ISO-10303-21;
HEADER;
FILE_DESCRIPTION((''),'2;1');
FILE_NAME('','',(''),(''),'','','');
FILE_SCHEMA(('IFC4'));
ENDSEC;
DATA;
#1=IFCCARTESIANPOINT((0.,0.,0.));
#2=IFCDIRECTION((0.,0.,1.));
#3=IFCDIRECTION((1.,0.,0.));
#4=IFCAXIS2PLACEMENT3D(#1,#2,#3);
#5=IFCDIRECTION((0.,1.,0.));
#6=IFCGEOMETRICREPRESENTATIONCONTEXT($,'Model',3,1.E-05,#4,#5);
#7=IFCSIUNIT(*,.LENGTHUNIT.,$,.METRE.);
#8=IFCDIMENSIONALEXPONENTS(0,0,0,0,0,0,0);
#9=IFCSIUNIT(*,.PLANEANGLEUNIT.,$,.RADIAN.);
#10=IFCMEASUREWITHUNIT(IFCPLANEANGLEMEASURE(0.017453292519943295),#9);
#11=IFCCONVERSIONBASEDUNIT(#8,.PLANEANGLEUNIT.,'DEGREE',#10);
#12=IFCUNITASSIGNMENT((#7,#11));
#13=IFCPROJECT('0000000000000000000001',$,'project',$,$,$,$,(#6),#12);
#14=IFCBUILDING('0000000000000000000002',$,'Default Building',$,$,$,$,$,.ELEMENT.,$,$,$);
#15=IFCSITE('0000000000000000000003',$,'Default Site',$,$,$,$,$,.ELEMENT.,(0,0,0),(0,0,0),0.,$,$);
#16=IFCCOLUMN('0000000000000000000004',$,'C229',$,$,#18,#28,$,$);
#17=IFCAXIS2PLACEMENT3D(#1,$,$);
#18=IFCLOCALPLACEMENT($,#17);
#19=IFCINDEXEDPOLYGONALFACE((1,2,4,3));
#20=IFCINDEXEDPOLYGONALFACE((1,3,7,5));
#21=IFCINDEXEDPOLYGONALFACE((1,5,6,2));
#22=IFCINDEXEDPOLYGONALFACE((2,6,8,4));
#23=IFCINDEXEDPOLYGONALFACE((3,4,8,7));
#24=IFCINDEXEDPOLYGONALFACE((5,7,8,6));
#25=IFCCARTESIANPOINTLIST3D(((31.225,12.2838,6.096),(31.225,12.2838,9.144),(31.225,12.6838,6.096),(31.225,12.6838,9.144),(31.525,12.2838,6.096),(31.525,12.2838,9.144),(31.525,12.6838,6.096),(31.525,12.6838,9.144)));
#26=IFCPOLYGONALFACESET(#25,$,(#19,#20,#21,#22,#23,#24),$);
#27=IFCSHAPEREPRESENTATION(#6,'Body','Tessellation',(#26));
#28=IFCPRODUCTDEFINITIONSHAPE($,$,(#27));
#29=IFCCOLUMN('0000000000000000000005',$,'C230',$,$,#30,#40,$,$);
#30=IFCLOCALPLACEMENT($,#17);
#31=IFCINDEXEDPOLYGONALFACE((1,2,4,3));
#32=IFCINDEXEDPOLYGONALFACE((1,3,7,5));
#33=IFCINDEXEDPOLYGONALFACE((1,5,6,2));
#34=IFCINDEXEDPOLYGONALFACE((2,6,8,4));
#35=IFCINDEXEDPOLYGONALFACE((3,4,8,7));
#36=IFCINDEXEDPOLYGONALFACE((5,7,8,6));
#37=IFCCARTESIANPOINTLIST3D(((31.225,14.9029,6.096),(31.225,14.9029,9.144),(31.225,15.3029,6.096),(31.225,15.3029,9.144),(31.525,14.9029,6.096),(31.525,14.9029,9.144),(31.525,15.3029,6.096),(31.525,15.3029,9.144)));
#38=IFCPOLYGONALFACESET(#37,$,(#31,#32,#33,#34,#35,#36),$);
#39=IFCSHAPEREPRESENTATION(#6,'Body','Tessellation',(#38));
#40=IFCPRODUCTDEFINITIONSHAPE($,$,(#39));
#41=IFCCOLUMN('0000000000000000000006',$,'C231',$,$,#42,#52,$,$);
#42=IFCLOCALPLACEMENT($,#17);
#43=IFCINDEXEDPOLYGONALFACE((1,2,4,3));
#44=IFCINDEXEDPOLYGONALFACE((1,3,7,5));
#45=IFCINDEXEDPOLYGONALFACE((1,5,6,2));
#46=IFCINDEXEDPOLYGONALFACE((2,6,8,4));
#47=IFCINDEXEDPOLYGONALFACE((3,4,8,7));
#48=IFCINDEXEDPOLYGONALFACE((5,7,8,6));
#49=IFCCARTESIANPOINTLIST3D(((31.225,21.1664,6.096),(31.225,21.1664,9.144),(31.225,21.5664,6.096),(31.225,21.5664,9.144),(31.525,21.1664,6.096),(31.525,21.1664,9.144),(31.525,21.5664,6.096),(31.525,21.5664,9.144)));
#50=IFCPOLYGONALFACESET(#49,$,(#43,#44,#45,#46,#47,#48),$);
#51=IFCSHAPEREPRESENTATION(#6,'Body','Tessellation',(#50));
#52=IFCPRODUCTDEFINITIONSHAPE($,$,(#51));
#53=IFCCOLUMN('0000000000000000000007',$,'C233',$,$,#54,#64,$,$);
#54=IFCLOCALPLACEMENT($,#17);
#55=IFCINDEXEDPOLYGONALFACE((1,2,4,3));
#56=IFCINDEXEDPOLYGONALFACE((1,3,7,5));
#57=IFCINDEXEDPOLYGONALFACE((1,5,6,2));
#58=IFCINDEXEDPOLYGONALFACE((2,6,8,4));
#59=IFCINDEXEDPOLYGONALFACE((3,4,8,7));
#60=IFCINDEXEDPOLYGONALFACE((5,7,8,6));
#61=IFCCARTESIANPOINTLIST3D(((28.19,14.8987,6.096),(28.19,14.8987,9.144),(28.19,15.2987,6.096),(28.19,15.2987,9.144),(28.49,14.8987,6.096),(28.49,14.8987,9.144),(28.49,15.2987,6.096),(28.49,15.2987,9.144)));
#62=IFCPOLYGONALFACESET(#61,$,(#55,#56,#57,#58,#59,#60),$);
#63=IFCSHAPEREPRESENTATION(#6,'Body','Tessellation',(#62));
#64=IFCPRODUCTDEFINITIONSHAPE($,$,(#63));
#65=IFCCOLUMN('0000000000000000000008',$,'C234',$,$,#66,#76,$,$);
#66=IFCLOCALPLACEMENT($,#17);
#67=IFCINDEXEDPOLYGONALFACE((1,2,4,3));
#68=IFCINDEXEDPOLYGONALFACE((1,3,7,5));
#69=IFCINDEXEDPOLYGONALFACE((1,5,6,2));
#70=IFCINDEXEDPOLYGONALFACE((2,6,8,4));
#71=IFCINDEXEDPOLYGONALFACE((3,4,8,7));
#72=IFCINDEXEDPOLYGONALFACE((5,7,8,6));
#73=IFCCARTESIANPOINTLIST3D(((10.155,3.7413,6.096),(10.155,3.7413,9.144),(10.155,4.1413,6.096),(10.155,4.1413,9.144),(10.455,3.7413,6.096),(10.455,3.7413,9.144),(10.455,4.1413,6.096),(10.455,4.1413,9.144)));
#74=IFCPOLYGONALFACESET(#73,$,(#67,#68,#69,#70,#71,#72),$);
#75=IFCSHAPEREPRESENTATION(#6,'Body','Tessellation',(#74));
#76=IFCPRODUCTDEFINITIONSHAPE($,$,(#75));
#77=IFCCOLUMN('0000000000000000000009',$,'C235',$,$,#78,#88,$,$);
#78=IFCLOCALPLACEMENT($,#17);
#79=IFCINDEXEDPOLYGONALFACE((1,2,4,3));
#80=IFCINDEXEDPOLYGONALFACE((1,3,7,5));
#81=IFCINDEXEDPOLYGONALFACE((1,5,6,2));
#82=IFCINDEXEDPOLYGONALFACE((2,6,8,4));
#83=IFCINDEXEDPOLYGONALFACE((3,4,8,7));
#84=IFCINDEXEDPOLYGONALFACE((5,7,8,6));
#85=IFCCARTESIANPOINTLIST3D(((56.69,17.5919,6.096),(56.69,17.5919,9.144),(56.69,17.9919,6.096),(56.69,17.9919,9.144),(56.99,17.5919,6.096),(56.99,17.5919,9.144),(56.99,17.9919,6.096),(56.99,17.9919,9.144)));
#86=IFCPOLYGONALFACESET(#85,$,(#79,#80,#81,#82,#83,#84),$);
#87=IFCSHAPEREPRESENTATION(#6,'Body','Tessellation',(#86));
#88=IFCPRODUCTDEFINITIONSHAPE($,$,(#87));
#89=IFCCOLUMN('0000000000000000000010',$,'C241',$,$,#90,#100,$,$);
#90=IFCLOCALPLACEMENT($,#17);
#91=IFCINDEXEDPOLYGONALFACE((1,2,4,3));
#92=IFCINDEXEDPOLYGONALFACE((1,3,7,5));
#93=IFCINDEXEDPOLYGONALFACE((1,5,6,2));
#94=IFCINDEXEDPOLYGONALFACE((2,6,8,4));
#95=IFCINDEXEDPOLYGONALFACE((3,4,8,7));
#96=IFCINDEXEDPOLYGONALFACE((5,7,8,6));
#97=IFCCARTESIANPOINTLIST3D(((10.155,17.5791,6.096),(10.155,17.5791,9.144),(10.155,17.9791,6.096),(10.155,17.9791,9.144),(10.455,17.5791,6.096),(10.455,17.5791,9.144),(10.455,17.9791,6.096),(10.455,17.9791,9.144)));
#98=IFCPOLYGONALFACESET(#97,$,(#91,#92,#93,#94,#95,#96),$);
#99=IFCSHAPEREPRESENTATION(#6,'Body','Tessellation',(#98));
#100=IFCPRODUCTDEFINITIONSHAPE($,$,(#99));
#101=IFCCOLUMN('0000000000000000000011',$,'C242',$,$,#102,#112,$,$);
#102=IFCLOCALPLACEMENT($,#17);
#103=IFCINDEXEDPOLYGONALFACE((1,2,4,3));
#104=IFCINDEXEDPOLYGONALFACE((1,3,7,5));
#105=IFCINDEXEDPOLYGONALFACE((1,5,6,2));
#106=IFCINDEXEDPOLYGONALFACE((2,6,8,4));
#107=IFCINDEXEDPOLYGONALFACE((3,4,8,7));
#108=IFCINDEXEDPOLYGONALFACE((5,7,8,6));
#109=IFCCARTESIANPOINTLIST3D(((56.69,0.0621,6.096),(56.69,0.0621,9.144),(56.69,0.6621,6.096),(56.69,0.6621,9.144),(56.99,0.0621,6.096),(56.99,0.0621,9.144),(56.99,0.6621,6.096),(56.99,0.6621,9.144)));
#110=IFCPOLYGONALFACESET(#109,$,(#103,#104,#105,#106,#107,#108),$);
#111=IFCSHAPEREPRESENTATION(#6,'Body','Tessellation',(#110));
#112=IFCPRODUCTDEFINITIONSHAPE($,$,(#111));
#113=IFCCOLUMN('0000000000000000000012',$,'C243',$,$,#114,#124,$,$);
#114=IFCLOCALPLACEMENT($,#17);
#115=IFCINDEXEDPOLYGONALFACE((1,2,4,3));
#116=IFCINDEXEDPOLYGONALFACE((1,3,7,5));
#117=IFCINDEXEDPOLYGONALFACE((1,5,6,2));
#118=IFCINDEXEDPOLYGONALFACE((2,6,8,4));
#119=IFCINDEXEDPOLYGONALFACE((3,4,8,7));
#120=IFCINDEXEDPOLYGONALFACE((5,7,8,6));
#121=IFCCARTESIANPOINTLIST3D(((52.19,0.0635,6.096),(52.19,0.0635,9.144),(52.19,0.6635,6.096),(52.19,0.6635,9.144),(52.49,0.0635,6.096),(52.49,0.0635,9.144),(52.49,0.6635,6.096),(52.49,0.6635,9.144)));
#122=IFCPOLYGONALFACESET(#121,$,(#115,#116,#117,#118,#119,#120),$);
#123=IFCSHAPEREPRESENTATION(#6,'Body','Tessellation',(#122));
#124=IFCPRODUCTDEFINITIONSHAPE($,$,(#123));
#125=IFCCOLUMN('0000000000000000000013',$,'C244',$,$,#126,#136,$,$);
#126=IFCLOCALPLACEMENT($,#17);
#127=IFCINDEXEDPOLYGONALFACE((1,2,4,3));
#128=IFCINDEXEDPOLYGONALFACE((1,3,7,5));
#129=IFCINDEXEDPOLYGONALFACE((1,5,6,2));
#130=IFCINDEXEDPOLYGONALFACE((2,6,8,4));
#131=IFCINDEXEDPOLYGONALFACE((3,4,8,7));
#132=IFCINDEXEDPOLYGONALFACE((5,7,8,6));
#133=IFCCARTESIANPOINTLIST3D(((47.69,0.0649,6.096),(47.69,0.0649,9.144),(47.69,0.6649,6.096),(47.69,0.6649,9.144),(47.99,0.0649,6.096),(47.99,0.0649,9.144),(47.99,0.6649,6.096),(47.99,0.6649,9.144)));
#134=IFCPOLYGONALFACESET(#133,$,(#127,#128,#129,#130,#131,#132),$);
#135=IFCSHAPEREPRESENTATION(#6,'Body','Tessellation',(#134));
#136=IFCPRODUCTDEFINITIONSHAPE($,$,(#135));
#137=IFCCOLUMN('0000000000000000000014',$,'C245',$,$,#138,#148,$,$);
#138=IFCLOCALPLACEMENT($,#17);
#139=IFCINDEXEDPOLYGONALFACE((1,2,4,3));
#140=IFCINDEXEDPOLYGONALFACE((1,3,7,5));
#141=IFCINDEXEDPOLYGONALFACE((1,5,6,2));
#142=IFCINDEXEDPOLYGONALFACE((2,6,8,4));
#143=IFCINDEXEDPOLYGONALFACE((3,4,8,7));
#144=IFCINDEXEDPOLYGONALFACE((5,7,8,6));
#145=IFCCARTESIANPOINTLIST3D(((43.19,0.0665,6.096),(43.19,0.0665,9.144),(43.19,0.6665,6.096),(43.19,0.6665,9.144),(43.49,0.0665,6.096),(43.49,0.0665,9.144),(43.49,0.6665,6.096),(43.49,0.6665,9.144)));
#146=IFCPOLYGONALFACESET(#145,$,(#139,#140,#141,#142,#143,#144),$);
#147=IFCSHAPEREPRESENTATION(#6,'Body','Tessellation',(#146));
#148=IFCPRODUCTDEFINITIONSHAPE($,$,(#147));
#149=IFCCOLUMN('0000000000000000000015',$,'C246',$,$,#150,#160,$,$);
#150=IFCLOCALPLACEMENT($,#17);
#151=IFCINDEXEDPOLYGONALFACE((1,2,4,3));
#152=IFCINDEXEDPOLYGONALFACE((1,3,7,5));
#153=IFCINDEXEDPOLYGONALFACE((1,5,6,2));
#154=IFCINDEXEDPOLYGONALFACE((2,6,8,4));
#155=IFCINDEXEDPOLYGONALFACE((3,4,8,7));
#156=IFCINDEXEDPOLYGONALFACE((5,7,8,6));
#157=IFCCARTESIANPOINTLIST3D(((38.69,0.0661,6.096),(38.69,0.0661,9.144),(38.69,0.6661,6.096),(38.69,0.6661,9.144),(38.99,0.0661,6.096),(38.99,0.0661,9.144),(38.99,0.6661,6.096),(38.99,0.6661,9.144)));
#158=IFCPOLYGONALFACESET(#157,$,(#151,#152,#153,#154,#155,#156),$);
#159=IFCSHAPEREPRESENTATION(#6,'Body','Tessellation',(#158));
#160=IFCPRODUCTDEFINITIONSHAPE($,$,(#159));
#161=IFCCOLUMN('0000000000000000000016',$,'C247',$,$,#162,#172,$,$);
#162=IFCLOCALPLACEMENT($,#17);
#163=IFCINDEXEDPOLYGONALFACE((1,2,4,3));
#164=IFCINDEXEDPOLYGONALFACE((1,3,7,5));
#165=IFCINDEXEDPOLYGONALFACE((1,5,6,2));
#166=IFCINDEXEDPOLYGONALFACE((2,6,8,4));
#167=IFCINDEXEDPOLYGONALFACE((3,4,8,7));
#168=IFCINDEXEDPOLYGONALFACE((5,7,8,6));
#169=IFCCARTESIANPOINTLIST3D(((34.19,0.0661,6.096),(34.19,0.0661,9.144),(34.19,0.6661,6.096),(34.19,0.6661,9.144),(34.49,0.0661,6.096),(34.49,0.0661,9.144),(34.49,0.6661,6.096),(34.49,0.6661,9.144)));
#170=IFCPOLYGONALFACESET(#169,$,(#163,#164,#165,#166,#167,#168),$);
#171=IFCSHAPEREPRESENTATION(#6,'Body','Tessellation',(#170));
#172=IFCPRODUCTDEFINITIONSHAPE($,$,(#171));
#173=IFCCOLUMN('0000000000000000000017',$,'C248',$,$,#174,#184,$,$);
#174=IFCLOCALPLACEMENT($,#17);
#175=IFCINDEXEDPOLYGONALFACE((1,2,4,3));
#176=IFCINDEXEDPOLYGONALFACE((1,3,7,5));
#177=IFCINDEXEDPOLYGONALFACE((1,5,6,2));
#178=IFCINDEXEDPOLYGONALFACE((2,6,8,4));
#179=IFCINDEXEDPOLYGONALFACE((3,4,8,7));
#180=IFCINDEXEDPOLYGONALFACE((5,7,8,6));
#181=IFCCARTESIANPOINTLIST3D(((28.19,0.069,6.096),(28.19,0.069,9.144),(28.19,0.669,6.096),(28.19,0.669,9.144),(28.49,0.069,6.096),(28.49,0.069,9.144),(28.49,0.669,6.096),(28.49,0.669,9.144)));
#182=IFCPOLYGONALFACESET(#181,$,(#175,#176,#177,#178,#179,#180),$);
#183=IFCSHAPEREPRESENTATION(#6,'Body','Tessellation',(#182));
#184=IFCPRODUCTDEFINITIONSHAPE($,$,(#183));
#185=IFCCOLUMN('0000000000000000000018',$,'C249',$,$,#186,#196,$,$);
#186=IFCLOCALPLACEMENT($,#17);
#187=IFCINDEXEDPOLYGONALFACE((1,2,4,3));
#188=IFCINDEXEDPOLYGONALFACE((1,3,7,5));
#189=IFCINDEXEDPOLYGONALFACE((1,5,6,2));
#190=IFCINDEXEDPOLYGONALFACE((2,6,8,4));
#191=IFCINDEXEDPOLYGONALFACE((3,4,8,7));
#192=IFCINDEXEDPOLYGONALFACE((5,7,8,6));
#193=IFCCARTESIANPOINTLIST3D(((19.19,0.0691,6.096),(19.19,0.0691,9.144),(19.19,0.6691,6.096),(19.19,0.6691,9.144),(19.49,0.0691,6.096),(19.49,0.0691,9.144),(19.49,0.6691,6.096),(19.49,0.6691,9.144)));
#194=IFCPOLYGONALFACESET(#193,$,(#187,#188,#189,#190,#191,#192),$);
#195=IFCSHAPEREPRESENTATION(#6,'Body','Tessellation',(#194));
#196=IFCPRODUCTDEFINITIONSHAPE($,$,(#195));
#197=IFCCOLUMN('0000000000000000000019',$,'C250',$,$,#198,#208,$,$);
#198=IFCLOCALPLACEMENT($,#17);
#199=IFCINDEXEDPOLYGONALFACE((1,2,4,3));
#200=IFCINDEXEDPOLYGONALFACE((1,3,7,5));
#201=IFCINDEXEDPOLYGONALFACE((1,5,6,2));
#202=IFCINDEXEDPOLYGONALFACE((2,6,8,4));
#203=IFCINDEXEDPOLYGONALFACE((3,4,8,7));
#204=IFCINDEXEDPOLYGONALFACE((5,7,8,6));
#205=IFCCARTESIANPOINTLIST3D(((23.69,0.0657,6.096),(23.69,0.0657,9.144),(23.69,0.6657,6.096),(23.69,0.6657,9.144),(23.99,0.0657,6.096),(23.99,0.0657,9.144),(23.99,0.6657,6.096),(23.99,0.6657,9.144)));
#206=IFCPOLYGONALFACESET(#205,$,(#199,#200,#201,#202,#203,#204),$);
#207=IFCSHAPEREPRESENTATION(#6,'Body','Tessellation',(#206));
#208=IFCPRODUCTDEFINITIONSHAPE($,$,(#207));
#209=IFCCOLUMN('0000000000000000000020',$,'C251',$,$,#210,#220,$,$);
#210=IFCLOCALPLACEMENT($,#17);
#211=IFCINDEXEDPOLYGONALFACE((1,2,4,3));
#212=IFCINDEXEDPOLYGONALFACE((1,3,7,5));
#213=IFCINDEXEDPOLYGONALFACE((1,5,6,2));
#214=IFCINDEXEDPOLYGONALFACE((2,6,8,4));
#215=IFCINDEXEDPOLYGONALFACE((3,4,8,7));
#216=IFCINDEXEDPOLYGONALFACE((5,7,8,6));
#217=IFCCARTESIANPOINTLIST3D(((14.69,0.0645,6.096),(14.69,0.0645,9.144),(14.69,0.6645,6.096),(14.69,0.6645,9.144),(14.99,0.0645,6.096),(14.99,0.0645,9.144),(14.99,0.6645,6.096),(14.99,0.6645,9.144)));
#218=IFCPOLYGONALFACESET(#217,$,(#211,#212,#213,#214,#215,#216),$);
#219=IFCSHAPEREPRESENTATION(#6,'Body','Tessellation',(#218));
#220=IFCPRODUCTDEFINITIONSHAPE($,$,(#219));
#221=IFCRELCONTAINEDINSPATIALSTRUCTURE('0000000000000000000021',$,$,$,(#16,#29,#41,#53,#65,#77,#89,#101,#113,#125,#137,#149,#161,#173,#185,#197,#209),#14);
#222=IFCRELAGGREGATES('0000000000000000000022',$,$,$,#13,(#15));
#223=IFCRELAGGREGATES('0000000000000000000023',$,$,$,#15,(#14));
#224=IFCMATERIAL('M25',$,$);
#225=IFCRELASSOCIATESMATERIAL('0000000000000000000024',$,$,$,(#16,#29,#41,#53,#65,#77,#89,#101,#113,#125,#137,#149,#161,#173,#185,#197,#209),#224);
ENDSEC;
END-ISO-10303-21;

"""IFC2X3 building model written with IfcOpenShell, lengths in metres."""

from ifc_helpers import new_model, entity, si_unit, converted_unit, direction, frame, frame_2d, origin_with_axes, place, context, project, spatial, rectangle, extrude, material, element, save


model = new_model("IFC2X3")

# Units and contexts
model_context = context("Model", 3, precision=1e-05, world=origin_with_axes(), true_north=direction((0.0, 1.0, 0.0)))
ifc_project = project(units=[si_unit("LENGTHUNIT", "METRE"), converted_unit("PLANEANGLEUNIT", "DEGREE", entity("IfcPlaneAngleMeasure", 0.017453292519943295), si_unit("PLANEANGLEUNIT", "RADIAN"), dimensions=[0, 0, 0, 0, 0, 0, 0])], contexts=[model_context])

# Site, building
site = spatial("IfcSite", under=ifc_project, Name="Default Site", CompositionType="ELEMENT", RefLatitude=(0, 0, 0), RefLongitude=(0, 0, 0), RefElevation=0.0)
building = spatial("IfcBuilding", under=site, Name="Default Building", CompositionType="ELEMENT")

# Columns
ifc_material = material(Name="M25")
placement = place(None, origin_with_axes())
element("IfcColumn", 1, at=placement, inside=building, material=ifc_material, Name="C229", context=model_context, shape_type="SweptSolid", body=[
    extrude(rectangle(XDim=0.3, YDim=0.4, at=frame_2d((0.0, 0.0), x_axis=(1.0, 0.0, 0.0))), frame((31.375, 12.4838, 6.096), z_axis=(0.0, 0.0, 1.0), x_axis=(1.0, 0.0, 0.0)), (0.0, 0.0, 1.0), 3.048),
])
element("IfcColumn", 2, at=placement, inside=building, material=ifc_material, Name="C230", context=model_context, shape_type="SweptSolid", body=[
    extrude(rectangle(XDim=0.3, YDim=0.4, at=frame_2d((0.0, 0.0), x_axis=(1.0, 0.0, 0.0))), frame((31.375, 15.1029, 6.096), z_axis=(0.0, 0.0, 1.0), x_axis=(1.0, 0.0, 0.0)), (0.0, 0.0, 1.0), 3.048),
])
element("IfcColumn", 3, at=placement, inside=building, material=ifc_material, Name="C231", context=model_context, shape_type="SweptSolid", body=[
    extrude(rectangle(XDim=0.3, YDim=0.4, at=frame_2d((0.0, 0.0), x_axis=(1.0, 0.0, 0.0))), frame((31.375, 21.3664, 6.096), z_axis=(0.0, 0.0, 1.0), x_axis=(1.0, 0.0, 0.0)), (0.0, 0.0, 1.0), 3.048),
])
element("IfcColumn", 4, at=placement, inside=building, material=ifc_material, Name="C233", context=model_context, shape_type="SweptSolid", body=[
    extrude(rectangle(XDim=0.3, YDim=0.4, at=frame_2d((0.0, 0.0), x_axis=(1.0, 0.0, 0.0))), frame((28.34, 15.0987, 6.096), z_axis=(0.0, 0.0, 1.0), x_axis=(1.0, 0.0, 0.0)), (0.0, 0.0, 1.0), 3.048),
])
element("IfcColumn", 5, at=placement, inside=building, material=ifc_material, Name="C234", context=model_context, shape_type="SweptSolid", body=[
    extrude(rectangle(XDim=0.3, YDim=0.4, at=frame_2d((0.0, 0.0), x_axis=(1.0, 0.0, 0.0))), frame((10.305, 3.9413, 6.096), z_axis=(0.0, 0.0, 1.0), x_axis=(1.0, 0.0, 0.0)), (0.0, 0.0, 1.0), 3.048),
])
element("IfcColumn", 6, at=placement, inside=building, material=ifc_material, Name="C235", context=model_context, shape_type="SweptSolid", body=[
    extrude(rectangle(XDim=0.3, YDim=0.4, at=frame_2d((0.0, 0.0), x_axis=(1.0, 0.0, 0.0))), frame((56.84, 17.7919, 6.096), z_axis=(0.0, 0.0, 1.0), x_axis=(1.0, 0.0, 0.0)), (0.0, 0.0, 1.0), 3.048),
])
element("IfcColumn", 7, at=placement, inside=building, material=ifc_material, Name="C241", context=model_context, shape_type="SweptSolid", body=[
    extrude(rectangle(XDim=0.3, YDim=0.4, at=frame_2d((0.0, 0.0), x_axis=(1.0, 0.0, 0.0))), frame((10.305, 17.7791, 6.096), z_axis=(0.0, 0.0, 1.0), x_axis=(1.0, 0.0, 0.0)), (0.0, 0.0, 1.0), 3.048),
])
element("IfcColumn", 8, at=placement, inside=building, material=ifc_material, Name="C242", context=model_context, shape_type="SweptSolid", body=[
    extrude(rectangle(XDim=0.3, YDim=0.6, at=frame_2d((0.0, 0.0), x_axis=(1.0, 0.0, 0.0))), frame((56.84, 0.3621, 6.096), z_axis=(0.0, 0.0, 1.0), x_axis=(1.0, 0.0, 0.0)), (0.0, 0.0, 1.0), 3.048),
])
element("IfcColumn", 9, at=placement, inside=building, material=ifc_material, Name="C243", context=model_context, shape_type="SweptSolid", body=[
    extrude(rectangle(XDim=0.3, YDim=0.6, at=frame_2d((0.0, 0.0), x_axis=(1.0, 0.0, 0.0))), frame((52.34, 0.3635, 6.096), z_axis=(0.0, 0.0, 1.0), x_axis=(1.0, 0.0, 0.0)), (0.0, 0.0, 1.0), 3.048),
])
element("IfcColumn", 10, at=placement, inside=building, material=ifc_material, Name="C244", context=model_context, shape_type="SweptSolid", body=[
    extrude(rectangle(XDim=0.3, YDim=0.6, at=frame_2d((0.0, 0.0), x_axis=(1.0, 0.0, 0.0))), frame((47.84, 0.3649, 6.096), z_axis=(0.0, 0.0, 1.0), x_axis=(1.0, 0.0, 0.0)), (0.0, 0.0, 1.0), 3.048),
])
element("IfcColumn", 11, at=placement, inside=building, material=ifc_material, Name="C245", context=model_context, shape_type="SweptSolid", body=[
    extrude(rectangle(XDim=0.3, YDim=0.6, at=frame_2d((0.0, 0.0), x_axis=(1.0, 0.0, 0.0))), frame((43.34, 0.3665, 6.096), z_axis=(0.0, 0.0, 1.0), x_axis=(1.0, 0.0, 0.0)), (0.0, 0.0, 1.0), 3.048),
])
element("IfcColumn", 12, at=placement, inside=building, material=ifc_material, Name="C246", context=model_context, shape_type="SweptSolid", body=[
    extrude(rectangle(XDim=0.3, YDim=0.6, at=frame_2d((0.0, 0.0), x_axis=(1.0, 0.0, 0.0))), frame((38.84, 0.3661, 6.096), z_axis=(0.0, 0.0, 1.0), x_axis=(1.0, 0.0, 0.0)), (0.0, 0.0, 1.0), 3.048),
])
element("IfcColumn", 13, at=placement, inside=building, material=ifc_material, Name="C247", context=model_context, shape_type="SweptSolid", body=[
    extrude(rectangle(XDim=0.3, YDim=0.6, at=frame_2d((0.0, 0.0), x_axis=(1.0, 0.0, 0.0))), frame((34.34, 0.3661, 6.096), z_axis=(0.0, 0.0, 1.0), x_axis=(1.0, 0.0, 0.0)), (0.0, 0.0, 1.0), 3.048),
])
element("IfcColumn", 14, at=placement, inside=building, material=ifc_material, Name="C248", context=model_context, shape_type="SweptSolid", body=[
    extrude(rectangle(XDim=0.3, YDim=0.6, at=frame_2d((0.0, 0.0), x_axis=(1.0, 0.0, 0.0))), frame((28.34, 0.369, 6.096), z_axis=(0.0, 0.0, 1.0), x_axis=(1.0, 0.0, 0.0)), (0.0, 0.0, 1.0), 3.048),
])
element("IfcColumn", 15, at=placement, inside=building, material=ifc_material, Name="C249", context=model_context, shape_type="SweptSolid", body=[
    extrude(rectangle(XDim=0.3, YDim=0.6, at=frame_2d((0.0, 0.0), x_axis=(1.0, 0.0, 0.0))), frame((19.34, 0.3691, 6.096), z_axis=(0.0, 0.0, 1.0), x_axis=(1.0, 0.0, 0.0)), (0.0, 0.0, 1.0), 3.048),
])
element("IfcColumn", 16, at=placement, inside=building, material=ifc_material, Name="C250", context=model_context, shape_type="SweptSolid", body=[
    extrude(rectangle(XDim=0.3, YDim=0.6, at=frame_2d((0.0, 0.0), x_axis=(1.0, 0.0, 0.0))), frame((23.84, 0.3657, 6.096), z_axis=(0.0, 0.0, 1.0), x_axis=(1.0, 0.0, 0.0)), (0.0, 0.0, 1.0), 3.048),
])
element("IfcColumn", 17, at=placement, inside=building, material=ifc_material, Name="C251", context=model_context, shape_type="SweptSolid", body=[
    extrude(rectangle(XDim=0.3, YDim=0.6, at=frame_2d((0.0, 0.0), x_axis=(1.0, 0.0, 0.0))), frame((14.84, 0.3645, 6.096), z_axis=(0.0, 0.0, 1.0), x_axis=(1.0, 0.0, 0.0)), (0.0, 0.0, 1.0), 3.048),
])

save(model, "model.ifc")
